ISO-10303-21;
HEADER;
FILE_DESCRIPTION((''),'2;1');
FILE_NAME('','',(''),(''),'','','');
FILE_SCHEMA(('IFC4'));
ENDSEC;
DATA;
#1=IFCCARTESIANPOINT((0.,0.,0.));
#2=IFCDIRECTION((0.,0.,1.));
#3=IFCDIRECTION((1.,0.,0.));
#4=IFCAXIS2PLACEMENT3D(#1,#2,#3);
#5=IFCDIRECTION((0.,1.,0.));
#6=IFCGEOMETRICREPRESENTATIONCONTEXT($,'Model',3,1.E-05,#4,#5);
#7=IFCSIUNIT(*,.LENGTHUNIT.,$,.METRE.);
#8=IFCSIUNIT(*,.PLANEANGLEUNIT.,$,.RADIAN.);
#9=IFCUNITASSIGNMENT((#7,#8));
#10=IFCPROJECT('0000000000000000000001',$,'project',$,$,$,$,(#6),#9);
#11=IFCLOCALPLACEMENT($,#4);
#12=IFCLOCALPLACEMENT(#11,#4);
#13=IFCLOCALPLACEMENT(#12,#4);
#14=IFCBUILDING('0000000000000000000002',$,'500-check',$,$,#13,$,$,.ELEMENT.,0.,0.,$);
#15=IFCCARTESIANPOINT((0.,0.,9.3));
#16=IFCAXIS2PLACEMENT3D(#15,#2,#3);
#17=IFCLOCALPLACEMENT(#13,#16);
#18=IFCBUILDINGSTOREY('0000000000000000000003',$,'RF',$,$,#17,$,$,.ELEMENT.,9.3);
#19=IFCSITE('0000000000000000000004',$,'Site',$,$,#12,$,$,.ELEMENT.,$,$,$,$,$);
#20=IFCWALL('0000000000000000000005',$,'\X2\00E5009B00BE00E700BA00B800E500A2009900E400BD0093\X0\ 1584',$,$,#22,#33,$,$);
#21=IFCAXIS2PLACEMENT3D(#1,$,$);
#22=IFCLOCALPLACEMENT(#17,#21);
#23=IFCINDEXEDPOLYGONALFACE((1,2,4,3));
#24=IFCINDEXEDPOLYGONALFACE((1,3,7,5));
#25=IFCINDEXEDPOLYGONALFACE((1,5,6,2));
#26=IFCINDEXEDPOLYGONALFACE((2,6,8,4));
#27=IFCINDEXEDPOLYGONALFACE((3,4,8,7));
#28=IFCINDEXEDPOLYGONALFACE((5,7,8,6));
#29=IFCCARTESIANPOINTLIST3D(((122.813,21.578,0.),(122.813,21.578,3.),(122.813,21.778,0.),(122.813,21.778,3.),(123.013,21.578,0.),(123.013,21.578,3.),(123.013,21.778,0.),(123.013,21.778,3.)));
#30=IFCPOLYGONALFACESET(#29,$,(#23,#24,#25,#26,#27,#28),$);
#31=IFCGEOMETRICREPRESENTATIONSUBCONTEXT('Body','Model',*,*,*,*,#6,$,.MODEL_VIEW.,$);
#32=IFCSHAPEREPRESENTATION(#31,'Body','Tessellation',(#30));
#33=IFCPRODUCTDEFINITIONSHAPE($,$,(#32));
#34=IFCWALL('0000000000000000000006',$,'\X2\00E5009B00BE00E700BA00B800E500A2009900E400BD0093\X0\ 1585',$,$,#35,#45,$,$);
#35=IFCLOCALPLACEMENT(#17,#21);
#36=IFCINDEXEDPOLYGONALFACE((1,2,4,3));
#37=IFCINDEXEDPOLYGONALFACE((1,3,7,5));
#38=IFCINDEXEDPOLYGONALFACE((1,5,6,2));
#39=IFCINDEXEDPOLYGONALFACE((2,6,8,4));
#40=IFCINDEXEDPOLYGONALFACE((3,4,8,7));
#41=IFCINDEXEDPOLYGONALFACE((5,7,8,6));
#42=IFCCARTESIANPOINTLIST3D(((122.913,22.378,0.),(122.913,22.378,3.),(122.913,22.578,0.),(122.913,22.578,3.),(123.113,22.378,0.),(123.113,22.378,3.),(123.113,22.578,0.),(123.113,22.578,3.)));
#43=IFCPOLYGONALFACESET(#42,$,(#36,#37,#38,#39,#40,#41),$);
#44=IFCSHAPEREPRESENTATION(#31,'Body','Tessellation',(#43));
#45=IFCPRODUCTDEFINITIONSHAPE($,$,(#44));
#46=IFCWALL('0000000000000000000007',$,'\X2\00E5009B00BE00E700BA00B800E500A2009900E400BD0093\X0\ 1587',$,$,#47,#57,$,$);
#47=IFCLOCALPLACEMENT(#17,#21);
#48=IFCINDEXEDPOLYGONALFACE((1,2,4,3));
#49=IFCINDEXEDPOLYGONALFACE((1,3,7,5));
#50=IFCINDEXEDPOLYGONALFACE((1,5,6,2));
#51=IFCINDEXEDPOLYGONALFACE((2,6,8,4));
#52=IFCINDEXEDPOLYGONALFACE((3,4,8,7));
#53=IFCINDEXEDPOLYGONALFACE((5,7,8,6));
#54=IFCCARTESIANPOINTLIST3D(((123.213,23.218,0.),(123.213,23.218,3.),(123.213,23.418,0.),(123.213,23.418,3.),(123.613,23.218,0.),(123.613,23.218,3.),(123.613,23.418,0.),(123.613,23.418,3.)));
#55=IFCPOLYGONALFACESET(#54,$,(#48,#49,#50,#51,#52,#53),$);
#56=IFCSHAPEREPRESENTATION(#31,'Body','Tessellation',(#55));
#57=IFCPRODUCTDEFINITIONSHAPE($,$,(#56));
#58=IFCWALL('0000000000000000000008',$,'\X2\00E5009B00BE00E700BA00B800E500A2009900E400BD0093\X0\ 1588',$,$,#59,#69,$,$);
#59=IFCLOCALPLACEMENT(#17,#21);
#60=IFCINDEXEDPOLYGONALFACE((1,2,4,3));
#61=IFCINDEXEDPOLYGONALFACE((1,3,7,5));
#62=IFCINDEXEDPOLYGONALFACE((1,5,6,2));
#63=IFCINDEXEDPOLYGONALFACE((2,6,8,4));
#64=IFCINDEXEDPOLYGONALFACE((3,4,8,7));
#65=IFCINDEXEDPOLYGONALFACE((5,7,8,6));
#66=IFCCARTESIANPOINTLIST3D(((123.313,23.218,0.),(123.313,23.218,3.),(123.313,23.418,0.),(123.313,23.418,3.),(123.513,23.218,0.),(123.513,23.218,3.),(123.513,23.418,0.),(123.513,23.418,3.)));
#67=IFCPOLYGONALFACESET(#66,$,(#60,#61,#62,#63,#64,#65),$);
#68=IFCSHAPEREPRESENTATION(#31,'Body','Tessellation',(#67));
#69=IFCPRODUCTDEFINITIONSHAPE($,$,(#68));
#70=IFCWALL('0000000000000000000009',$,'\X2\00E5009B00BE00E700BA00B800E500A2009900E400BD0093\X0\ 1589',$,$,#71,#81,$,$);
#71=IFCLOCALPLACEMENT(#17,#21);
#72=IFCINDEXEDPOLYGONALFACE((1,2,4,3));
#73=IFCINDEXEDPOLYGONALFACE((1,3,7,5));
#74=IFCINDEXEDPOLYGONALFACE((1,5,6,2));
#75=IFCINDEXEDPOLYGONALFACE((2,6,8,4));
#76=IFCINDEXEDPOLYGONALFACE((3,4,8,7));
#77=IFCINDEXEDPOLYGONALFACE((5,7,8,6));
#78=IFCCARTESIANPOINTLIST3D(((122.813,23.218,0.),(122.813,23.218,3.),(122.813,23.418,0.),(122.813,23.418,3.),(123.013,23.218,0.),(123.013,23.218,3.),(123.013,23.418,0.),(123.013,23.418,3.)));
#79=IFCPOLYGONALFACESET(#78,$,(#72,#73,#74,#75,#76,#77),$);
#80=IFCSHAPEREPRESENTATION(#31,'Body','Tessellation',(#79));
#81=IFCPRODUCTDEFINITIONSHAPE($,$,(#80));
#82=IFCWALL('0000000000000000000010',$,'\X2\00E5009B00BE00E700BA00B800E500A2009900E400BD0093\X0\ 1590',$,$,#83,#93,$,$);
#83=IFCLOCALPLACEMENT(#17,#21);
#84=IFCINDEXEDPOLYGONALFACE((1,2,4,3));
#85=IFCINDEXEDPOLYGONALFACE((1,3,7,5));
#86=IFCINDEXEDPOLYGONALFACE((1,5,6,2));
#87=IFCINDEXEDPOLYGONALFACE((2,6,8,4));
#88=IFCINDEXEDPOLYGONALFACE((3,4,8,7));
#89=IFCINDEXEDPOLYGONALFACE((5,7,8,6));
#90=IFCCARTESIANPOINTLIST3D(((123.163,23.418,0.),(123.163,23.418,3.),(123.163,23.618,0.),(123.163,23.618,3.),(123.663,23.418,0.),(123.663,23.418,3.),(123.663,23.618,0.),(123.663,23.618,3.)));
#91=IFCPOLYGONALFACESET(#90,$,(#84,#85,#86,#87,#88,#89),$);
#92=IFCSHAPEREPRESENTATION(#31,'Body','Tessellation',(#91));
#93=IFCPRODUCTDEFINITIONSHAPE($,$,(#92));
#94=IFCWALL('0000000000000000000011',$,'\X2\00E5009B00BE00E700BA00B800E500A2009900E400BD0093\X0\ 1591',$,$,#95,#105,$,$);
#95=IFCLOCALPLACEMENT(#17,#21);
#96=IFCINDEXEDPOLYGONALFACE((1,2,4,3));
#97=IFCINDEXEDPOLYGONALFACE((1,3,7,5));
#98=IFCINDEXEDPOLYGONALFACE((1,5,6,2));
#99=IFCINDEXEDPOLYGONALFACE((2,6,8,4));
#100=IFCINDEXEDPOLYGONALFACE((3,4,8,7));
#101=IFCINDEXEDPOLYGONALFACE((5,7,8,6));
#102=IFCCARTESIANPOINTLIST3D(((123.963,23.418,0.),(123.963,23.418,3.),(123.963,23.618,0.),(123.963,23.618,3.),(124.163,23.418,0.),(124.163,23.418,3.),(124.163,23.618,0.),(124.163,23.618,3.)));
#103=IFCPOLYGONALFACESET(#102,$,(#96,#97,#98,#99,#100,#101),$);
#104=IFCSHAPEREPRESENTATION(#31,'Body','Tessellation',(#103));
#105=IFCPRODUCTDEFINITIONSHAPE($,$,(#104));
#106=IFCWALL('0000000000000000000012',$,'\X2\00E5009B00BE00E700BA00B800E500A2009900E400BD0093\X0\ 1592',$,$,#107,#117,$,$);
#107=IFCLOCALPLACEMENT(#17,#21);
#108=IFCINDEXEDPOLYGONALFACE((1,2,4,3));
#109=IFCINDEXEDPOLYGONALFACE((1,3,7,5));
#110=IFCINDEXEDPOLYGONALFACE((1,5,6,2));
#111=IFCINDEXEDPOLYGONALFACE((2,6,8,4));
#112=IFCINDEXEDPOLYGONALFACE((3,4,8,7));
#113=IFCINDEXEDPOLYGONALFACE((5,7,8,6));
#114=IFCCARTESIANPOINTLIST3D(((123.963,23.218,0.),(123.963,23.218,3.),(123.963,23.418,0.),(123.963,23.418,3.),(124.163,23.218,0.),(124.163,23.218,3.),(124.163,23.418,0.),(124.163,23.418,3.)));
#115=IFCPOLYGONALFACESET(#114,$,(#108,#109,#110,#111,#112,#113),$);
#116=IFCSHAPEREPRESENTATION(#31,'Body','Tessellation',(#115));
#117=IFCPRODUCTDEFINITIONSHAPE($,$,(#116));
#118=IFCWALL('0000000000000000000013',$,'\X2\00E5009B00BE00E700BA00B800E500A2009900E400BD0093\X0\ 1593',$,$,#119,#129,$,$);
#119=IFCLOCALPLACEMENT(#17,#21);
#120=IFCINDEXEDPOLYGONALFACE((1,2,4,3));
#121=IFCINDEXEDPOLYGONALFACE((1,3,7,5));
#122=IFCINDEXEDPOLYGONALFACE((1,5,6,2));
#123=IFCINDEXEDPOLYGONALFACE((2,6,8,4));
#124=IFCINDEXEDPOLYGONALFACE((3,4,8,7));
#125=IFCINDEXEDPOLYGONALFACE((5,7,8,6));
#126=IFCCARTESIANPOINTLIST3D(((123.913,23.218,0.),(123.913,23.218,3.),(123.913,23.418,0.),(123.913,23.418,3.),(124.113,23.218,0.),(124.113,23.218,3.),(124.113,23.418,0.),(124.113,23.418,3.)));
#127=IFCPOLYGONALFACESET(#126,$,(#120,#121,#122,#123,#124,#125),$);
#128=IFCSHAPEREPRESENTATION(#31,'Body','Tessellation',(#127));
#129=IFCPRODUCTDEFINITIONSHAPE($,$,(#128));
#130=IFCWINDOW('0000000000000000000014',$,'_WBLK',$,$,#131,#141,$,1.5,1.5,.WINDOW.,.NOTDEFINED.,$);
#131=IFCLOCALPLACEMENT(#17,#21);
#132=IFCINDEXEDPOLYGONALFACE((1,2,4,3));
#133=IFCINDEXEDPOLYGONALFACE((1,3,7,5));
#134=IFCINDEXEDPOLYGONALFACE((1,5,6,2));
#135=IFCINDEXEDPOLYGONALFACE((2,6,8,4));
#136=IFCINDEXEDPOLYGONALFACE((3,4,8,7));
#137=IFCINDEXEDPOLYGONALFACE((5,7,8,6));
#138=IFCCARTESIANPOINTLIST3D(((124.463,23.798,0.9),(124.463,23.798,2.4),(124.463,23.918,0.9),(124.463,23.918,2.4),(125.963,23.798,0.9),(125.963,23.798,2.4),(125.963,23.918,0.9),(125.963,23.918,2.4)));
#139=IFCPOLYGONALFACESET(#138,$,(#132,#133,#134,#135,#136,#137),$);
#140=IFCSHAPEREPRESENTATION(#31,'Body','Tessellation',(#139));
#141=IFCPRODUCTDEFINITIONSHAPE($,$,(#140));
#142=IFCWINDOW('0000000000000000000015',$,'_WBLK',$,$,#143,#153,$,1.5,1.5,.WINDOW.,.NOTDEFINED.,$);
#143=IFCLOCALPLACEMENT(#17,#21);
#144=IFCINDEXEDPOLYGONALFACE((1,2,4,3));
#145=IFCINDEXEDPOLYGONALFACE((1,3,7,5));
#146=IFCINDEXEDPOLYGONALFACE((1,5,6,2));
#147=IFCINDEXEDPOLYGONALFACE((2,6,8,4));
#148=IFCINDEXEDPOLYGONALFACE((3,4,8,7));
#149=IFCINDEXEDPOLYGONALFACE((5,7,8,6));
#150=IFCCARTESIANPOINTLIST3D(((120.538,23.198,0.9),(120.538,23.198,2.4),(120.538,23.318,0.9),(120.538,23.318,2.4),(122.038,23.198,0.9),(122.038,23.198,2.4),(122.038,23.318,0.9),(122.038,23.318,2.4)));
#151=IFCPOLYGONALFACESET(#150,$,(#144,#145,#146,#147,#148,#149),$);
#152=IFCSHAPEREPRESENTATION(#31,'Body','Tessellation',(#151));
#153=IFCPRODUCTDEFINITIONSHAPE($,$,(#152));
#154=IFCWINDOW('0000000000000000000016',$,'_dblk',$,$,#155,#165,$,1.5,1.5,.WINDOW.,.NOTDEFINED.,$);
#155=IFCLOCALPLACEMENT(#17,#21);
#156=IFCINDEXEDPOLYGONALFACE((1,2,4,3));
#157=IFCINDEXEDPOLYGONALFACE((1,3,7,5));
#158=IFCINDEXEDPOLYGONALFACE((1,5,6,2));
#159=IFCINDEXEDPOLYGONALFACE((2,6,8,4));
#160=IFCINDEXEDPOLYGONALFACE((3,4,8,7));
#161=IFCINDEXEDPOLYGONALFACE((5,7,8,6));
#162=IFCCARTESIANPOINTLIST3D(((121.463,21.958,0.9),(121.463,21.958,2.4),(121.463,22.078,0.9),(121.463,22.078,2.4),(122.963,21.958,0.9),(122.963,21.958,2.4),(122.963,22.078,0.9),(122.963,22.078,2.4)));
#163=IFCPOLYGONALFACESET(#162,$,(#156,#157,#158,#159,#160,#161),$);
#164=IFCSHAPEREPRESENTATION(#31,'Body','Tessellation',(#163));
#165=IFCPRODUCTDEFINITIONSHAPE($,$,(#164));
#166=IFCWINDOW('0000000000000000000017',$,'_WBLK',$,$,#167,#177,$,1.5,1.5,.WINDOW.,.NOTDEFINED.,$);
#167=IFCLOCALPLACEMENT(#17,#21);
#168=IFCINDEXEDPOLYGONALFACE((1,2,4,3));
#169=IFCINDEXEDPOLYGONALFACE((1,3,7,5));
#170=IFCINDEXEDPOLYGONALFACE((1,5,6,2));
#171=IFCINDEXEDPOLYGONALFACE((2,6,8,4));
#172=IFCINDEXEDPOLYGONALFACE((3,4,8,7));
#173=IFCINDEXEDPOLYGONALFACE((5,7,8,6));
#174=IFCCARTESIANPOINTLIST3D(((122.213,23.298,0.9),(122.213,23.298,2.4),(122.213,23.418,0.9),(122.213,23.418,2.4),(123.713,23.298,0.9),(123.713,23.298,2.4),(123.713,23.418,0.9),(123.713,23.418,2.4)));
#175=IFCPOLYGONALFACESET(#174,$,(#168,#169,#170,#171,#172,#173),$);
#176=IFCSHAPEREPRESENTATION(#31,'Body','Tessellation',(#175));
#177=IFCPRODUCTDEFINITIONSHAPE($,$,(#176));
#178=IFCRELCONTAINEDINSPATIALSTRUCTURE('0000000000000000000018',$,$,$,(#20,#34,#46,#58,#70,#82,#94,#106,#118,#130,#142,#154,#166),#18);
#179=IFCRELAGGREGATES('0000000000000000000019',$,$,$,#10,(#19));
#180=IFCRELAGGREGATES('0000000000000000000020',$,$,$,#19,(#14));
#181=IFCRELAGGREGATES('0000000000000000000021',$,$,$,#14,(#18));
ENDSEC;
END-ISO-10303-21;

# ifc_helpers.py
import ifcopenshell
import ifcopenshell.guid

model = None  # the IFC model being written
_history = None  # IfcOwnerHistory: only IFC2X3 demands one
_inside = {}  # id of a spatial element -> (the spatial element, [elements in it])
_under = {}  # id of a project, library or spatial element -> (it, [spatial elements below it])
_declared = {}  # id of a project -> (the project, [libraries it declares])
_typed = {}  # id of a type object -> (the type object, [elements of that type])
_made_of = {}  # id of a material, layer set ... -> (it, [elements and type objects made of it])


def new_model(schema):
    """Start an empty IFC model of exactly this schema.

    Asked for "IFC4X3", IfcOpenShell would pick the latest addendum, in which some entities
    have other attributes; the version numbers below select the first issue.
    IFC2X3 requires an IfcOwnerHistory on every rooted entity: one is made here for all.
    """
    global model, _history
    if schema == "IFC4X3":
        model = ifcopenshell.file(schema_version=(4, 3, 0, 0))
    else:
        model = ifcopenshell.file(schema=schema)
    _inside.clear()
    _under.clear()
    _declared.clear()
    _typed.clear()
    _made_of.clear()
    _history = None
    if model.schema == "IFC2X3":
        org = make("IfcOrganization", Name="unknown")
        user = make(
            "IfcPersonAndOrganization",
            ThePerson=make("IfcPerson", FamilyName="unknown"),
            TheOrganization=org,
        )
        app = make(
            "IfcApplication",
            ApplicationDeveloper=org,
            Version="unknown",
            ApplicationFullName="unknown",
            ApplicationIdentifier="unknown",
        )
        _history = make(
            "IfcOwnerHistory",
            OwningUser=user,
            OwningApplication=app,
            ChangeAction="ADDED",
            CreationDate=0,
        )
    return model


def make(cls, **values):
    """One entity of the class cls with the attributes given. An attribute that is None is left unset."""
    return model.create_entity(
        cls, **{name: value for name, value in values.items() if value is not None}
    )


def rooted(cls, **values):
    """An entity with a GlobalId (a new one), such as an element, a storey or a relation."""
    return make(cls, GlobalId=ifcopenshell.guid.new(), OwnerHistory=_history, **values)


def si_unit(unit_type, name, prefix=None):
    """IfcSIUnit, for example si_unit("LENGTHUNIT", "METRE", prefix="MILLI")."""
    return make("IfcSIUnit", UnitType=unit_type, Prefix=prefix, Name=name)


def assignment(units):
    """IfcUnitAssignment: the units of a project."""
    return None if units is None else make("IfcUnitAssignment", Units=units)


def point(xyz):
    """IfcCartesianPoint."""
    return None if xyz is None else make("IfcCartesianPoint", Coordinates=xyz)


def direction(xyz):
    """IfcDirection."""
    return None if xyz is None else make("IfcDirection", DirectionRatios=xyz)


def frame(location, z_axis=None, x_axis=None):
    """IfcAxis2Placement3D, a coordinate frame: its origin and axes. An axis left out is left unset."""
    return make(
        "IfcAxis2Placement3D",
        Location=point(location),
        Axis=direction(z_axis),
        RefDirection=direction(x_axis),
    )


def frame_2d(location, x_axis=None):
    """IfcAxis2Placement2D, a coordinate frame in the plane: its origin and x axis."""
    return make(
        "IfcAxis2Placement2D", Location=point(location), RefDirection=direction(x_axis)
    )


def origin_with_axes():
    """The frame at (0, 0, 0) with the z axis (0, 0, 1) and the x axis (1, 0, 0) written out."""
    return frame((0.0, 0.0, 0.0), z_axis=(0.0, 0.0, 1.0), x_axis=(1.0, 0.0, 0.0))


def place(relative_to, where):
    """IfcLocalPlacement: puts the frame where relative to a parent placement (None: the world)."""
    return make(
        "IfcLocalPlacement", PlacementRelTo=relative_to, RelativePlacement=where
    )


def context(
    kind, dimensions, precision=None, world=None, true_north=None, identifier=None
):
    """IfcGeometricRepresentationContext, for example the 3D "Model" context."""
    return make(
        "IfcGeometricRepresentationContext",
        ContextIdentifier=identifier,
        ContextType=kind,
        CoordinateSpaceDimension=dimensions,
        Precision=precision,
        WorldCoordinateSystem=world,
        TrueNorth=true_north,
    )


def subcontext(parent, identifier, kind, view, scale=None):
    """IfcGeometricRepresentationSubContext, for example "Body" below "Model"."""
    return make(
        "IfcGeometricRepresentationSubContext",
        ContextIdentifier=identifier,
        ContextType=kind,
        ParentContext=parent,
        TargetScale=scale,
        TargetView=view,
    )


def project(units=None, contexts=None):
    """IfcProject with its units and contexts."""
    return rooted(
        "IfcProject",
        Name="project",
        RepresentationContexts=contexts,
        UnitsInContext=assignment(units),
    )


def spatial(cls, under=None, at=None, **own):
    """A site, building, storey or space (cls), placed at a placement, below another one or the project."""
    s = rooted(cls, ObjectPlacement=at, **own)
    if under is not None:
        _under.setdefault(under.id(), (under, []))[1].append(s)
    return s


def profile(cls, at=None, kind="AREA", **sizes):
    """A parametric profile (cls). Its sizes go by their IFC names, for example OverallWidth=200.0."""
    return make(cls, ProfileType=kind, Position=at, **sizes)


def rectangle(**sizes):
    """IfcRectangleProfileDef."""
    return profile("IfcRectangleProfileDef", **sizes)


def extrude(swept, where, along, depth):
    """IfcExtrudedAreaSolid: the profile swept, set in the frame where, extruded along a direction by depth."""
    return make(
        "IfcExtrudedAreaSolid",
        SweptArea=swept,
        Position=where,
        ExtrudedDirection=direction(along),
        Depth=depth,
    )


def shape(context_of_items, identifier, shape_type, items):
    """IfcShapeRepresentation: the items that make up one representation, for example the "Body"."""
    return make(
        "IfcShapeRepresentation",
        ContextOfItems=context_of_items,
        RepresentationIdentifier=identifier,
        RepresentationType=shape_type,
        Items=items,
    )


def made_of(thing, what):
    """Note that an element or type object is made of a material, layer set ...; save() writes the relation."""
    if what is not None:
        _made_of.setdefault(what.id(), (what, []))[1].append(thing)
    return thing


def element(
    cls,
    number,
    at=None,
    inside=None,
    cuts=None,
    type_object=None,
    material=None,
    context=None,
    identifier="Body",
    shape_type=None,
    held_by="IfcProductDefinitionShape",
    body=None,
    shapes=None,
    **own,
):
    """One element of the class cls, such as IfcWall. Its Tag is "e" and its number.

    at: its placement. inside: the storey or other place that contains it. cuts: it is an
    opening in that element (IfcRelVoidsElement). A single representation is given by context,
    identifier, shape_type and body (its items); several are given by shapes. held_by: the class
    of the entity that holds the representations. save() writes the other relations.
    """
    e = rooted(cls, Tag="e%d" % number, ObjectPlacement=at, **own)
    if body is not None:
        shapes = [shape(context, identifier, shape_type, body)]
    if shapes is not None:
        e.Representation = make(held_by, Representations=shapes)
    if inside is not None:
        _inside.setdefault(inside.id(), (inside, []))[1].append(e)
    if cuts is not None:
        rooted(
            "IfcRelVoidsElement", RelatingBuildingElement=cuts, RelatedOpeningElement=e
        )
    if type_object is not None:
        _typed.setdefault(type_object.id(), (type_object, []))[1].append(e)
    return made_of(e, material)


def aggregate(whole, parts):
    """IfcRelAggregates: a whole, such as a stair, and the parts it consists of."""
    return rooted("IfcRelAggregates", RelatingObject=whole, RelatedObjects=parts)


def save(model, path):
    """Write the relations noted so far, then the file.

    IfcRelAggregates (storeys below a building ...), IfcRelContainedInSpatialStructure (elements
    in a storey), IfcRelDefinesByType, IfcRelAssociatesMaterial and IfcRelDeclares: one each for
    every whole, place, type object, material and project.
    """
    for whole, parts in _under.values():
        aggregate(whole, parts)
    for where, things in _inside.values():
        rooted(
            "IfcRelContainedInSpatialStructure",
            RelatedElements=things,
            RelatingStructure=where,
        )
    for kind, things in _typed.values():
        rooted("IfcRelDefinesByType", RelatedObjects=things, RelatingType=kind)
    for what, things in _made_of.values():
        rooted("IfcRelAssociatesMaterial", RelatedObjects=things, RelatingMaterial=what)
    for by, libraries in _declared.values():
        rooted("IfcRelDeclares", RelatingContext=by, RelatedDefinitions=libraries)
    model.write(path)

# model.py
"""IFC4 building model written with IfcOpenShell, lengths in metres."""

from ifc_helpers import new_model, si_unit, direction, frame, frame_2d, origin_with_axes, place, context, subcontext, project, spatial, rectangle, extrude, element, save


model = new_model("IFC4")

# Units and contexts
model_context = context("Model", 3, precision=1e-05, world=origin_with_axes(), true_north=direction((0.0, 1.0, 0.0)))
body_context = subcontext(model_context, "Body", "Model", "MODEL_VIEW")
ifc_project = project(units=[si_unit("LENGTHUNIT", "METRE"), si_unit("PLANEANGLEUNIT", "RADIAN")], contexts=[model_context])

# Site, building, storey
placement = place(None, origin_with_axes())
site_placement = place(placement, origin_with_axes())
site = spatial("IfcSite", under=ifc_project, at=site_placement, Name="Site", CompositionType="ELEMENT")
building_placement = place(site_placement, origin_with_axes())
building = spatial("IfcBuilding", under=site, at=building_placement, Name="500-check", CompositionType="ELEMENT", ElevationOfRefHeight=0.0, ElevationOfTerrain=0.0)
storey_placement = place(building_placement, frame((0.0, 0.0, 9.3), z_axis=(0.0, 0.0, 1.0), x_axis=(1.0, 0.0, 0.0)))
storey = spatial("IfcBuildingStorey", under=building, at=storey_placement, Name="RF", CompositionType="ELEMENT", Elevation=9.3)

# Walls
for number, where, z_axis, x_axis, name in (
    (1, (122.913, 21.678, 0.0), (0.0, 0.0, 1.0), (0.0, -1.0, 0.0), "å\u009b¾çº¸å¢\u0099ä½\u0093 1584"),
    (2, (123.013, 22.478, 0.0), (0.0, 0.0, 1.0), (-1.0, 0.0, 0.0), "å\u009b¾çº¸å¢\u0099ä½\u0093 1585"),
):
    element("IfcWall", number, at=place(storey_placement, frame(where, z_axis=z_axis, x_axis=x_axis)), inside=storey, Name=name, context=body_context, shape_type="SweptSolid", body=[
        extrude(rectangle(XDim=0.2, YDim=0.2, at=frame_2d((0.0, 0.0), x_axis=(1.0, 0.0, 0.0))), frame((0.0, 0.0, 0.0), z_axis=(0.0, 0.0, 1.0)), (0.0, 0.0, 1.0), 3.0),
    ])
wall_1_placement = place(storey_placement, frame((123.413, 23.318, 0.0), z_axis=(0.0, 0.0, 1.0), x_axis=(-1.0, 0.0, 0.0)))
element("IfcWall", 3, at=wall_1_placement, inside=storey, Name="å\u009b¾çº¸å¢\u0099ä½\u0093 1587", context=body_context, shape_type="SweptSolid", body=[
    extrude(rectangle(XDim=0.4, YDim=0.2, at=frame_2d((0.0, 0.0), x_axis=(1.0, 0.0, 0.0))), frame((0.0, 0.0, 0.0), z_axis=(0.0, 0.0, 1.0)), (0.0, 0.0, 1.0), 3.0),
])
for number, where, z_axis, x_axis, name in (
    (4, (123.413, 23.318, 0.0), (0.0, 0.0, 1.0), (0.0, 1.0, 0.0), "å\u009b¾çº¸å¢\u0099ä½\u0093 1588"),
    (5, (122.913, 23.318, 0.0), (0.0, 0.0, 1.0), (0.0, 1.0, 0.0), "å\u009b¾çº¸å¢\u0099ä½\u0093 1589"),
):
    element("IfcWall", number, at=place(storey_placement, frame(where, z_axis=z_axis, x_axis=x_axis)), inside=storey, Name=name, context=body_context, shape_type="SweptSolid", body=[
        extrude(rectangle(XDim=0.2, YDim=0.2, at=frame_2d((0.0, 0.0), x_axis=(1.0, 0.0, 0.0))), frame((0.0, 0.0, 0.0), z_axis=(0.0, 0.0, 1.0)), (0.0, 0.0, 1.0), 3.0),
    ])
wall_2_placement = place(storey_placement, frame((123.413, 23.518, 0.0), z_axis=(0.0, 0.0, 1.0), x_axis=(-1.0, 0.0, 0.0)))
element("IfcWall", 6, at=wall_2_placement, inside=storey, Name="å\u009b¾çº¸å¢\u0099ä½\u0093 1590", context=body_context, shape_type="SweptSolid", body=[
    extrude(rectangle(XDim=0.5, YDim=0.2, at=frame_2d((0.0, 0.0), x_axis=(1.0, 0.0, 0.0))), frame((0.0, 0.0, 0.0), z_axis=(0.0, 0.0, 1.0)), (0.0, 0.0, 1.0), 3.0),
])
for number, where, z_axis, x_axis, name in (
    (7, (124.063, 23.518, 0.0), (0.0, 0.0, 1.0), (-1.0, 0.0, 0.0), "å\u009b¾çº¸å¢\u0099ä½\u0093 1591"),
    (8, (124.063, 23.318, 0.0), (0.0, 0.0, 1.0), (-1.0, 0.0, 0.0), "å\u009b¾çº¸å¢\u0099ä½\u0093 1592"),
    (9, (124.013, 23.318, 0.0), (0.0, 0.0, 1.0), (0.0, 1.0, 0.0), "å\u009b¾çº¸å¢\u0099ä½\u0093 1593"),
):
    element("IfcWall", number, at=place(storey_placement, frame(where, z_axis=z_axis, x_axis=x_axis)), inside=storey, Name=name, context=body_context, shape_type="SweptSolid", body=[
        extrude(rectangle(XDim=0.2, YDim=0.2, at=frame_2d((0.0, 0.0), x_axis=(1.0, 0.0, 0.0))), frame((0.0, 0.0, 0.0), z_axis=(0.0, 0.0, 1.0)), (0.0, 0.0, 1.0), 3.0),
    ])

# Windows
for number, where, z_axis, x_axis, name in (
    (10, (125.213, 23.858, 0.9), (0.0, 0.0, 1.0), (1.0, 0.0, 0.0), "_WBLK"),
    (11, (121.288, 23.258, 0.9), (0.0, 0.0, 1.0), (1.0, 0.0, 0.0), "_WBLK"),
    (12, (122.213, 22.018, 0.9), (0.0, 0.0, 1.0), (1.0, 0.0, 0.0), "_dblk"),
    (13, (122.963, 23.358, 0.9), (0.0, 0.0, 1.0), (1.0, 0.0, 0.0), "_WBLK"),
):
    element("IfcWindow", number, at=place(storey_placement, frame(where, z_axis=z_axis, x_axis=x_axis)), inside=storey, Name=name, OverallHeight=1.5, OverallWidth=1.5, PartitioningType="NOTDEFINED", PredefinedType="WINDOW", context=body_context, shape_type="SweptSolid", body=[
        extrude(rectangle(XDim=1.5, YDim=0.12, at=frame_2d((0.0, 0.0), x_axis=(1.0, 0.0, 0.0))), frame((0.0, 0.0, 0.0), z_axis=(0.0, 0.0, 1.0)), (0.0, 0.0, 1.0), 1.5),
    ])

save(model, "model.ifc")
